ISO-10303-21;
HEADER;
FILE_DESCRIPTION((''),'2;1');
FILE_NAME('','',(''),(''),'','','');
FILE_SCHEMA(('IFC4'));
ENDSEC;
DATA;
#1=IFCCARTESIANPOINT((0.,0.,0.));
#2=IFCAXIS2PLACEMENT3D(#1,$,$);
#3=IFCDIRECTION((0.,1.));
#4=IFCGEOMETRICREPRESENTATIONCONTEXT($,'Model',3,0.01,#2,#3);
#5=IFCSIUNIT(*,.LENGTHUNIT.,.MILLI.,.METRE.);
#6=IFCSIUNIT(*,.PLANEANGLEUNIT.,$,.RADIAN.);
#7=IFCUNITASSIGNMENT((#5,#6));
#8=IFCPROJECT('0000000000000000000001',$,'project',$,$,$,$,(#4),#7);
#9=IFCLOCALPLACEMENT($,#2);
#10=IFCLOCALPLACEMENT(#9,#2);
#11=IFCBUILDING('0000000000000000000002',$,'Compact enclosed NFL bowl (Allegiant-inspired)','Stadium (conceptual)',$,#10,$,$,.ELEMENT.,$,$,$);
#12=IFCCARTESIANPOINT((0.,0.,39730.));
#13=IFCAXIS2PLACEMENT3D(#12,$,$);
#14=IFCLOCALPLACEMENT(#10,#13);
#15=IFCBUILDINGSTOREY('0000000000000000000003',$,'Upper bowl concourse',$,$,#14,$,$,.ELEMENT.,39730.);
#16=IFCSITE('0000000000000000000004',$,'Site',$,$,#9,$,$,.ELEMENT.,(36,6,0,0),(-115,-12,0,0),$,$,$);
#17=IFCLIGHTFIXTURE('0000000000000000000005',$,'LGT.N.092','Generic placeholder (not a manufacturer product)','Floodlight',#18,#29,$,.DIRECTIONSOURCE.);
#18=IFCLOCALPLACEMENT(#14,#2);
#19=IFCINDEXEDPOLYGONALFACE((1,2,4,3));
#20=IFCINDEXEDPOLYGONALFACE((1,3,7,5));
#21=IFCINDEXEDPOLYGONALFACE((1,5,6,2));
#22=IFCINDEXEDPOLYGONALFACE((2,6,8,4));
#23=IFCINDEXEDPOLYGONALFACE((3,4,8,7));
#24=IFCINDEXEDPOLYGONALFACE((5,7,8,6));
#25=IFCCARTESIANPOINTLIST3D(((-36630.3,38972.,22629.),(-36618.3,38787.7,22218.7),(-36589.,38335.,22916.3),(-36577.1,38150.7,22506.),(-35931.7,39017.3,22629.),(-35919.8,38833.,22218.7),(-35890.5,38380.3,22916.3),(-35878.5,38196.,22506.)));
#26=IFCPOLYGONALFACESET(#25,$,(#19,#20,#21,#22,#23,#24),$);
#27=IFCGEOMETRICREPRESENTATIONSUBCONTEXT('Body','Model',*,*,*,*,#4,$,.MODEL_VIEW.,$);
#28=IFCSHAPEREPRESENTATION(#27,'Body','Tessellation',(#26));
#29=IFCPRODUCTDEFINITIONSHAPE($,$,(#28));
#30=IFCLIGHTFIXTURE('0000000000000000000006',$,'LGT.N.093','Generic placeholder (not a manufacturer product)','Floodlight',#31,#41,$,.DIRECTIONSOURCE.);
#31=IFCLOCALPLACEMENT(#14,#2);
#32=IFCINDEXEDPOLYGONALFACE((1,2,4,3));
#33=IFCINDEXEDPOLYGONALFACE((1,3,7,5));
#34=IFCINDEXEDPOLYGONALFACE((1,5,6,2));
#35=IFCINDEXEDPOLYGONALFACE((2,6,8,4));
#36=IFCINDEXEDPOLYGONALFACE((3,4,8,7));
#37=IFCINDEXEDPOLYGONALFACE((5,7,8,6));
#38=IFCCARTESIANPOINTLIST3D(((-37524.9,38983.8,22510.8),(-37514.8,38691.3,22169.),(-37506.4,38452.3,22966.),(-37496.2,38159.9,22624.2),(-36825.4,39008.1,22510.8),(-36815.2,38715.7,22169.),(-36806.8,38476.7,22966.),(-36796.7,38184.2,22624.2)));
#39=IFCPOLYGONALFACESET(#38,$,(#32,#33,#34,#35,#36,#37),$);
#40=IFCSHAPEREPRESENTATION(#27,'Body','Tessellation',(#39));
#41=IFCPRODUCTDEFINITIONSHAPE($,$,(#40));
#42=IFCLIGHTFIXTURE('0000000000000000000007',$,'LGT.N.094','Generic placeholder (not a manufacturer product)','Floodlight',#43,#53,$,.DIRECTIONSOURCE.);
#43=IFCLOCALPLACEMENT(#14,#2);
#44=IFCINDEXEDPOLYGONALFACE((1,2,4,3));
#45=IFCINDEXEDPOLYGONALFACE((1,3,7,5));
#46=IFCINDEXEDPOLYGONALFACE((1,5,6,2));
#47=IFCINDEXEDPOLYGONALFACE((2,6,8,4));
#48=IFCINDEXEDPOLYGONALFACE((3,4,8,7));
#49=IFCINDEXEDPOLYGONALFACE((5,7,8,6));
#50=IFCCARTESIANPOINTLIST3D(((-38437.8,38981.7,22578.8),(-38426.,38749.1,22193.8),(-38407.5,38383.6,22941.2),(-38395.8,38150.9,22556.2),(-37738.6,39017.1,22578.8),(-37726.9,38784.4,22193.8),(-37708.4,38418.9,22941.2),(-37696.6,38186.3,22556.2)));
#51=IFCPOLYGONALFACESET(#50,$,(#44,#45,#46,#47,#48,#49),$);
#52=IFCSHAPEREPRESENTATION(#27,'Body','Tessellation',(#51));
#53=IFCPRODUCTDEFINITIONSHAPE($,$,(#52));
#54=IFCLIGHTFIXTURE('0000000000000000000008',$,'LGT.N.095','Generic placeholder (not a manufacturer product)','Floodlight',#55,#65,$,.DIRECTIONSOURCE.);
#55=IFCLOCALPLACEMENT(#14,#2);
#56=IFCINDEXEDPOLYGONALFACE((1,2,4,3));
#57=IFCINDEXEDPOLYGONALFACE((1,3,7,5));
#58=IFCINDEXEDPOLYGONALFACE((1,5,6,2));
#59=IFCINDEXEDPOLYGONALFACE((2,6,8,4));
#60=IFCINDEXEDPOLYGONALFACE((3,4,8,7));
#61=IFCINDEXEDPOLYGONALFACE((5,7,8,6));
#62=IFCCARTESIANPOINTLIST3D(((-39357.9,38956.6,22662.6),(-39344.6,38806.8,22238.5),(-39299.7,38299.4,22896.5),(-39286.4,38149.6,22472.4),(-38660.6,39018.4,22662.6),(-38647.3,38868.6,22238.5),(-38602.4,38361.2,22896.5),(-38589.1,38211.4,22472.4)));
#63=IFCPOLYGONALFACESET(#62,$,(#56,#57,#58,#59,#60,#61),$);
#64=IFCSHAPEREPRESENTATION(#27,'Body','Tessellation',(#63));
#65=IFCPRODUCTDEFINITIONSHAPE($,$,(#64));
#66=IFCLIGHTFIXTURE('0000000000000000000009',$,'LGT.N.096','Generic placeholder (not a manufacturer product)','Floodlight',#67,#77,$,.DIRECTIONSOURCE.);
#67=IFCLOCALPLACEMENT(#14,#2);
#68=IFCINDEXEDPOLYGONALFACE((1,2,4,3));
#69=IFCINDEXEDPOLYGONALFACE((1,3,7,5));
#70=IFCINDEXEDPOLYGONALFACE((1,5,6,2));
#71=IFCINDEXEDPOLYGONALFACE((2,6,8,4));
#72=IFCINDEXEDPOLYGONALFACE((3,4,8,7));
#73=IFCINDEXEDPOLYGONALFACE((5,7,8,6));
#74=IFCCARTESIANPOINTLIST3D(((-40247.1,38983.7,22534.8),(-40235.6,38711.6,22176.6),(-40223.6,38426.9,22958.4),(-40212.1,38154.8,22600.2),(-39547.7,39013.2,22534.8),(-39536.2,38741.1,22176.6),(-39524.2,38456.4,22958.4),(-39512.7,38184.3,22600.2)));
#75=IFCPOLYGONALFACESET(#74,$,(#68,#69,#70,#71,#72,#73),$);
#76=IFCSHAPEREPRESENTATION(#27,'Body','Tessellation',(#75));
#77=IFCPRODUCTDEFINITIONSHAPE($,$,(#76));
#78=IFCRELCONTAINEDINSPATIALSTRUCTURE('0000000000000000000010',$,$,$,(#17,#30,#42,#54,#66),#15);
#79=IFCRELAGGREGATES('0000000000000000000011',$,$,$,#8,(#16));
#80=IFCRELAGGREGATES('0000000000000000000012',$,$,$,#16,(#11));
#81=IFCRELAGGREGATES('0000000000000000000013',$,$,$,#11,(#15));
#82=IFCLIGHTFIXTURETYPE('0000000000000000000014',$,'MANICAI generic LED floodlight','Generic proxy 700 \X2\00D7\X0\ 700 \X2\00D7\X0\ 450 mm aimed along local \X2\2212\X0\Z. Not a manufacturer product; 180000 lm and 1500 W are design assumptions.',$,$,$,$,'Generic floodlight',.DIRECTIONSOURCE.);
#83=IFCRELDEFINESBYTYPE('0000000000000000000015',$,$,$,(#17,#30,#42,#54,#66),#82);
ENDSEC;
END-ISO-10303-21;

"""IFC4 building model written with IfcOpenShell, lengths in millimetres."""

from ifc_helpers import new_model, si_unit, direction, frame, origin, place, context, subcontext, project, spatial, rectangle, extrude, source, transform, mapped, type_object, type_shapes, element, save


model = new_model("IFC4")

# Units and contexts
model_context = context("Model", 3, precision=0.01, world=origin(), true_north=direction((0.0, 1.0)))
body_context = subcontext(model_context, "Body", "Model", "MODEL_VIEW")
ifc_project = project(units=[si_unit("LENGTHUNIT", "METRE", prefix="MILLI"), si_unit("PLANEANGLEUNIT", "RADIAN")], contexts=[model_context])

# Site, building, storey
site_placement = place(None, origin())
site = spatial("IfcSite", under=ifc_project, at=site_placement, Name="Site", CompositionType="ELEMENT", RefLatitude=(36, 6, 0, 0), RefLongitude=(-115, -12, 0, 0))
building_placement = place(site_placement, origin())
building = spatial("IfcBuilding", under=site, at=building_placement, Name="Compact enclosed NFL bowl (Allegiant-inspired)", Description="Stadium (conceptual)", CompositionType="ELEMENT")
storey_placement = place(building_placement, frame((0.0, 0.0, 39730.0)))
storey = spatial("IfcBuildingStorey", under=building, at=storey_placement, Name="Upper bowl concourse", CompositionType="ELEMENT", Elevation=39730.0)

# Light fixtures
light_fixture_type = type_object("IfcLightFixtureType", Name="MANICAI generic LED floodlight", Description="Generic proxy 700 × 700 × 450 mm aimed along local −Z. Not a manufacturer product; 180000 lm and 1500 W are design assumptions.", ElementType="Generic floodlight", PredefinedType="DIRECTIONSOURCE")
shared_shape = source(origin(), body_context, "Body", "SweptSolid", [
    extrude(rectangle(XDim=700.0, YDim=700.0), frame((0.0, 0.0, -225.0)), (0.0, 0.0, 1.0), 450.0),
])
type_shapes(light_fixture_type, [shared_shape])
for number, where, z_axis, x_axis, name in (
    (1, (-36254.4, 38584.0, 22567.5), (-0.026535, 0.409538, 0.911907), (-0.997908, -0.064656, 0.0), "LGT.N.092"),
    (2, (-37160.8, 38584.0, 22567.5), (-0.022658, 0.649906, 0.759677), (-0.999393, -0.034842, 0.0), "LGT.N.093"),
    (3, (-38067.2, 38584.0, 22567.5), (-0.02614, 0.517043, 0.85556), (-0.998724, -0.050492, 0.0), "LGT.N.094"),
    (4, (-38973.5, 38584.0, 22567.5), (-0.029482, 0.332861, 0.942515), (-0.9961, -0.088226, 0.0), "LGT.N.095"),
    (5, (-39879.9, 38584.0, 22567.5), (-0.02548, 0.604667, 0.796071), (-0.999113, -0.042102, 0.0), "LGT.N.096"),
):
    element("IfcLightFixture", number, at=place(storey_placement, frame(where, z_axis=z_axis, x_axis=x_axis)), inside=storey, type_object=light_fixture_type, Name=name, Description="Generic placeholder (not a manufacturer product)", ObjectType="Floodlight", PredefinedType="DIRECTIONSOURCE", context=body_context, shape_type="MappedRepresentation", body=[
        mapped(shared_shape, transform((0.0, 0.0, 0.0))),
    ])

save(model, "model.ifc")
